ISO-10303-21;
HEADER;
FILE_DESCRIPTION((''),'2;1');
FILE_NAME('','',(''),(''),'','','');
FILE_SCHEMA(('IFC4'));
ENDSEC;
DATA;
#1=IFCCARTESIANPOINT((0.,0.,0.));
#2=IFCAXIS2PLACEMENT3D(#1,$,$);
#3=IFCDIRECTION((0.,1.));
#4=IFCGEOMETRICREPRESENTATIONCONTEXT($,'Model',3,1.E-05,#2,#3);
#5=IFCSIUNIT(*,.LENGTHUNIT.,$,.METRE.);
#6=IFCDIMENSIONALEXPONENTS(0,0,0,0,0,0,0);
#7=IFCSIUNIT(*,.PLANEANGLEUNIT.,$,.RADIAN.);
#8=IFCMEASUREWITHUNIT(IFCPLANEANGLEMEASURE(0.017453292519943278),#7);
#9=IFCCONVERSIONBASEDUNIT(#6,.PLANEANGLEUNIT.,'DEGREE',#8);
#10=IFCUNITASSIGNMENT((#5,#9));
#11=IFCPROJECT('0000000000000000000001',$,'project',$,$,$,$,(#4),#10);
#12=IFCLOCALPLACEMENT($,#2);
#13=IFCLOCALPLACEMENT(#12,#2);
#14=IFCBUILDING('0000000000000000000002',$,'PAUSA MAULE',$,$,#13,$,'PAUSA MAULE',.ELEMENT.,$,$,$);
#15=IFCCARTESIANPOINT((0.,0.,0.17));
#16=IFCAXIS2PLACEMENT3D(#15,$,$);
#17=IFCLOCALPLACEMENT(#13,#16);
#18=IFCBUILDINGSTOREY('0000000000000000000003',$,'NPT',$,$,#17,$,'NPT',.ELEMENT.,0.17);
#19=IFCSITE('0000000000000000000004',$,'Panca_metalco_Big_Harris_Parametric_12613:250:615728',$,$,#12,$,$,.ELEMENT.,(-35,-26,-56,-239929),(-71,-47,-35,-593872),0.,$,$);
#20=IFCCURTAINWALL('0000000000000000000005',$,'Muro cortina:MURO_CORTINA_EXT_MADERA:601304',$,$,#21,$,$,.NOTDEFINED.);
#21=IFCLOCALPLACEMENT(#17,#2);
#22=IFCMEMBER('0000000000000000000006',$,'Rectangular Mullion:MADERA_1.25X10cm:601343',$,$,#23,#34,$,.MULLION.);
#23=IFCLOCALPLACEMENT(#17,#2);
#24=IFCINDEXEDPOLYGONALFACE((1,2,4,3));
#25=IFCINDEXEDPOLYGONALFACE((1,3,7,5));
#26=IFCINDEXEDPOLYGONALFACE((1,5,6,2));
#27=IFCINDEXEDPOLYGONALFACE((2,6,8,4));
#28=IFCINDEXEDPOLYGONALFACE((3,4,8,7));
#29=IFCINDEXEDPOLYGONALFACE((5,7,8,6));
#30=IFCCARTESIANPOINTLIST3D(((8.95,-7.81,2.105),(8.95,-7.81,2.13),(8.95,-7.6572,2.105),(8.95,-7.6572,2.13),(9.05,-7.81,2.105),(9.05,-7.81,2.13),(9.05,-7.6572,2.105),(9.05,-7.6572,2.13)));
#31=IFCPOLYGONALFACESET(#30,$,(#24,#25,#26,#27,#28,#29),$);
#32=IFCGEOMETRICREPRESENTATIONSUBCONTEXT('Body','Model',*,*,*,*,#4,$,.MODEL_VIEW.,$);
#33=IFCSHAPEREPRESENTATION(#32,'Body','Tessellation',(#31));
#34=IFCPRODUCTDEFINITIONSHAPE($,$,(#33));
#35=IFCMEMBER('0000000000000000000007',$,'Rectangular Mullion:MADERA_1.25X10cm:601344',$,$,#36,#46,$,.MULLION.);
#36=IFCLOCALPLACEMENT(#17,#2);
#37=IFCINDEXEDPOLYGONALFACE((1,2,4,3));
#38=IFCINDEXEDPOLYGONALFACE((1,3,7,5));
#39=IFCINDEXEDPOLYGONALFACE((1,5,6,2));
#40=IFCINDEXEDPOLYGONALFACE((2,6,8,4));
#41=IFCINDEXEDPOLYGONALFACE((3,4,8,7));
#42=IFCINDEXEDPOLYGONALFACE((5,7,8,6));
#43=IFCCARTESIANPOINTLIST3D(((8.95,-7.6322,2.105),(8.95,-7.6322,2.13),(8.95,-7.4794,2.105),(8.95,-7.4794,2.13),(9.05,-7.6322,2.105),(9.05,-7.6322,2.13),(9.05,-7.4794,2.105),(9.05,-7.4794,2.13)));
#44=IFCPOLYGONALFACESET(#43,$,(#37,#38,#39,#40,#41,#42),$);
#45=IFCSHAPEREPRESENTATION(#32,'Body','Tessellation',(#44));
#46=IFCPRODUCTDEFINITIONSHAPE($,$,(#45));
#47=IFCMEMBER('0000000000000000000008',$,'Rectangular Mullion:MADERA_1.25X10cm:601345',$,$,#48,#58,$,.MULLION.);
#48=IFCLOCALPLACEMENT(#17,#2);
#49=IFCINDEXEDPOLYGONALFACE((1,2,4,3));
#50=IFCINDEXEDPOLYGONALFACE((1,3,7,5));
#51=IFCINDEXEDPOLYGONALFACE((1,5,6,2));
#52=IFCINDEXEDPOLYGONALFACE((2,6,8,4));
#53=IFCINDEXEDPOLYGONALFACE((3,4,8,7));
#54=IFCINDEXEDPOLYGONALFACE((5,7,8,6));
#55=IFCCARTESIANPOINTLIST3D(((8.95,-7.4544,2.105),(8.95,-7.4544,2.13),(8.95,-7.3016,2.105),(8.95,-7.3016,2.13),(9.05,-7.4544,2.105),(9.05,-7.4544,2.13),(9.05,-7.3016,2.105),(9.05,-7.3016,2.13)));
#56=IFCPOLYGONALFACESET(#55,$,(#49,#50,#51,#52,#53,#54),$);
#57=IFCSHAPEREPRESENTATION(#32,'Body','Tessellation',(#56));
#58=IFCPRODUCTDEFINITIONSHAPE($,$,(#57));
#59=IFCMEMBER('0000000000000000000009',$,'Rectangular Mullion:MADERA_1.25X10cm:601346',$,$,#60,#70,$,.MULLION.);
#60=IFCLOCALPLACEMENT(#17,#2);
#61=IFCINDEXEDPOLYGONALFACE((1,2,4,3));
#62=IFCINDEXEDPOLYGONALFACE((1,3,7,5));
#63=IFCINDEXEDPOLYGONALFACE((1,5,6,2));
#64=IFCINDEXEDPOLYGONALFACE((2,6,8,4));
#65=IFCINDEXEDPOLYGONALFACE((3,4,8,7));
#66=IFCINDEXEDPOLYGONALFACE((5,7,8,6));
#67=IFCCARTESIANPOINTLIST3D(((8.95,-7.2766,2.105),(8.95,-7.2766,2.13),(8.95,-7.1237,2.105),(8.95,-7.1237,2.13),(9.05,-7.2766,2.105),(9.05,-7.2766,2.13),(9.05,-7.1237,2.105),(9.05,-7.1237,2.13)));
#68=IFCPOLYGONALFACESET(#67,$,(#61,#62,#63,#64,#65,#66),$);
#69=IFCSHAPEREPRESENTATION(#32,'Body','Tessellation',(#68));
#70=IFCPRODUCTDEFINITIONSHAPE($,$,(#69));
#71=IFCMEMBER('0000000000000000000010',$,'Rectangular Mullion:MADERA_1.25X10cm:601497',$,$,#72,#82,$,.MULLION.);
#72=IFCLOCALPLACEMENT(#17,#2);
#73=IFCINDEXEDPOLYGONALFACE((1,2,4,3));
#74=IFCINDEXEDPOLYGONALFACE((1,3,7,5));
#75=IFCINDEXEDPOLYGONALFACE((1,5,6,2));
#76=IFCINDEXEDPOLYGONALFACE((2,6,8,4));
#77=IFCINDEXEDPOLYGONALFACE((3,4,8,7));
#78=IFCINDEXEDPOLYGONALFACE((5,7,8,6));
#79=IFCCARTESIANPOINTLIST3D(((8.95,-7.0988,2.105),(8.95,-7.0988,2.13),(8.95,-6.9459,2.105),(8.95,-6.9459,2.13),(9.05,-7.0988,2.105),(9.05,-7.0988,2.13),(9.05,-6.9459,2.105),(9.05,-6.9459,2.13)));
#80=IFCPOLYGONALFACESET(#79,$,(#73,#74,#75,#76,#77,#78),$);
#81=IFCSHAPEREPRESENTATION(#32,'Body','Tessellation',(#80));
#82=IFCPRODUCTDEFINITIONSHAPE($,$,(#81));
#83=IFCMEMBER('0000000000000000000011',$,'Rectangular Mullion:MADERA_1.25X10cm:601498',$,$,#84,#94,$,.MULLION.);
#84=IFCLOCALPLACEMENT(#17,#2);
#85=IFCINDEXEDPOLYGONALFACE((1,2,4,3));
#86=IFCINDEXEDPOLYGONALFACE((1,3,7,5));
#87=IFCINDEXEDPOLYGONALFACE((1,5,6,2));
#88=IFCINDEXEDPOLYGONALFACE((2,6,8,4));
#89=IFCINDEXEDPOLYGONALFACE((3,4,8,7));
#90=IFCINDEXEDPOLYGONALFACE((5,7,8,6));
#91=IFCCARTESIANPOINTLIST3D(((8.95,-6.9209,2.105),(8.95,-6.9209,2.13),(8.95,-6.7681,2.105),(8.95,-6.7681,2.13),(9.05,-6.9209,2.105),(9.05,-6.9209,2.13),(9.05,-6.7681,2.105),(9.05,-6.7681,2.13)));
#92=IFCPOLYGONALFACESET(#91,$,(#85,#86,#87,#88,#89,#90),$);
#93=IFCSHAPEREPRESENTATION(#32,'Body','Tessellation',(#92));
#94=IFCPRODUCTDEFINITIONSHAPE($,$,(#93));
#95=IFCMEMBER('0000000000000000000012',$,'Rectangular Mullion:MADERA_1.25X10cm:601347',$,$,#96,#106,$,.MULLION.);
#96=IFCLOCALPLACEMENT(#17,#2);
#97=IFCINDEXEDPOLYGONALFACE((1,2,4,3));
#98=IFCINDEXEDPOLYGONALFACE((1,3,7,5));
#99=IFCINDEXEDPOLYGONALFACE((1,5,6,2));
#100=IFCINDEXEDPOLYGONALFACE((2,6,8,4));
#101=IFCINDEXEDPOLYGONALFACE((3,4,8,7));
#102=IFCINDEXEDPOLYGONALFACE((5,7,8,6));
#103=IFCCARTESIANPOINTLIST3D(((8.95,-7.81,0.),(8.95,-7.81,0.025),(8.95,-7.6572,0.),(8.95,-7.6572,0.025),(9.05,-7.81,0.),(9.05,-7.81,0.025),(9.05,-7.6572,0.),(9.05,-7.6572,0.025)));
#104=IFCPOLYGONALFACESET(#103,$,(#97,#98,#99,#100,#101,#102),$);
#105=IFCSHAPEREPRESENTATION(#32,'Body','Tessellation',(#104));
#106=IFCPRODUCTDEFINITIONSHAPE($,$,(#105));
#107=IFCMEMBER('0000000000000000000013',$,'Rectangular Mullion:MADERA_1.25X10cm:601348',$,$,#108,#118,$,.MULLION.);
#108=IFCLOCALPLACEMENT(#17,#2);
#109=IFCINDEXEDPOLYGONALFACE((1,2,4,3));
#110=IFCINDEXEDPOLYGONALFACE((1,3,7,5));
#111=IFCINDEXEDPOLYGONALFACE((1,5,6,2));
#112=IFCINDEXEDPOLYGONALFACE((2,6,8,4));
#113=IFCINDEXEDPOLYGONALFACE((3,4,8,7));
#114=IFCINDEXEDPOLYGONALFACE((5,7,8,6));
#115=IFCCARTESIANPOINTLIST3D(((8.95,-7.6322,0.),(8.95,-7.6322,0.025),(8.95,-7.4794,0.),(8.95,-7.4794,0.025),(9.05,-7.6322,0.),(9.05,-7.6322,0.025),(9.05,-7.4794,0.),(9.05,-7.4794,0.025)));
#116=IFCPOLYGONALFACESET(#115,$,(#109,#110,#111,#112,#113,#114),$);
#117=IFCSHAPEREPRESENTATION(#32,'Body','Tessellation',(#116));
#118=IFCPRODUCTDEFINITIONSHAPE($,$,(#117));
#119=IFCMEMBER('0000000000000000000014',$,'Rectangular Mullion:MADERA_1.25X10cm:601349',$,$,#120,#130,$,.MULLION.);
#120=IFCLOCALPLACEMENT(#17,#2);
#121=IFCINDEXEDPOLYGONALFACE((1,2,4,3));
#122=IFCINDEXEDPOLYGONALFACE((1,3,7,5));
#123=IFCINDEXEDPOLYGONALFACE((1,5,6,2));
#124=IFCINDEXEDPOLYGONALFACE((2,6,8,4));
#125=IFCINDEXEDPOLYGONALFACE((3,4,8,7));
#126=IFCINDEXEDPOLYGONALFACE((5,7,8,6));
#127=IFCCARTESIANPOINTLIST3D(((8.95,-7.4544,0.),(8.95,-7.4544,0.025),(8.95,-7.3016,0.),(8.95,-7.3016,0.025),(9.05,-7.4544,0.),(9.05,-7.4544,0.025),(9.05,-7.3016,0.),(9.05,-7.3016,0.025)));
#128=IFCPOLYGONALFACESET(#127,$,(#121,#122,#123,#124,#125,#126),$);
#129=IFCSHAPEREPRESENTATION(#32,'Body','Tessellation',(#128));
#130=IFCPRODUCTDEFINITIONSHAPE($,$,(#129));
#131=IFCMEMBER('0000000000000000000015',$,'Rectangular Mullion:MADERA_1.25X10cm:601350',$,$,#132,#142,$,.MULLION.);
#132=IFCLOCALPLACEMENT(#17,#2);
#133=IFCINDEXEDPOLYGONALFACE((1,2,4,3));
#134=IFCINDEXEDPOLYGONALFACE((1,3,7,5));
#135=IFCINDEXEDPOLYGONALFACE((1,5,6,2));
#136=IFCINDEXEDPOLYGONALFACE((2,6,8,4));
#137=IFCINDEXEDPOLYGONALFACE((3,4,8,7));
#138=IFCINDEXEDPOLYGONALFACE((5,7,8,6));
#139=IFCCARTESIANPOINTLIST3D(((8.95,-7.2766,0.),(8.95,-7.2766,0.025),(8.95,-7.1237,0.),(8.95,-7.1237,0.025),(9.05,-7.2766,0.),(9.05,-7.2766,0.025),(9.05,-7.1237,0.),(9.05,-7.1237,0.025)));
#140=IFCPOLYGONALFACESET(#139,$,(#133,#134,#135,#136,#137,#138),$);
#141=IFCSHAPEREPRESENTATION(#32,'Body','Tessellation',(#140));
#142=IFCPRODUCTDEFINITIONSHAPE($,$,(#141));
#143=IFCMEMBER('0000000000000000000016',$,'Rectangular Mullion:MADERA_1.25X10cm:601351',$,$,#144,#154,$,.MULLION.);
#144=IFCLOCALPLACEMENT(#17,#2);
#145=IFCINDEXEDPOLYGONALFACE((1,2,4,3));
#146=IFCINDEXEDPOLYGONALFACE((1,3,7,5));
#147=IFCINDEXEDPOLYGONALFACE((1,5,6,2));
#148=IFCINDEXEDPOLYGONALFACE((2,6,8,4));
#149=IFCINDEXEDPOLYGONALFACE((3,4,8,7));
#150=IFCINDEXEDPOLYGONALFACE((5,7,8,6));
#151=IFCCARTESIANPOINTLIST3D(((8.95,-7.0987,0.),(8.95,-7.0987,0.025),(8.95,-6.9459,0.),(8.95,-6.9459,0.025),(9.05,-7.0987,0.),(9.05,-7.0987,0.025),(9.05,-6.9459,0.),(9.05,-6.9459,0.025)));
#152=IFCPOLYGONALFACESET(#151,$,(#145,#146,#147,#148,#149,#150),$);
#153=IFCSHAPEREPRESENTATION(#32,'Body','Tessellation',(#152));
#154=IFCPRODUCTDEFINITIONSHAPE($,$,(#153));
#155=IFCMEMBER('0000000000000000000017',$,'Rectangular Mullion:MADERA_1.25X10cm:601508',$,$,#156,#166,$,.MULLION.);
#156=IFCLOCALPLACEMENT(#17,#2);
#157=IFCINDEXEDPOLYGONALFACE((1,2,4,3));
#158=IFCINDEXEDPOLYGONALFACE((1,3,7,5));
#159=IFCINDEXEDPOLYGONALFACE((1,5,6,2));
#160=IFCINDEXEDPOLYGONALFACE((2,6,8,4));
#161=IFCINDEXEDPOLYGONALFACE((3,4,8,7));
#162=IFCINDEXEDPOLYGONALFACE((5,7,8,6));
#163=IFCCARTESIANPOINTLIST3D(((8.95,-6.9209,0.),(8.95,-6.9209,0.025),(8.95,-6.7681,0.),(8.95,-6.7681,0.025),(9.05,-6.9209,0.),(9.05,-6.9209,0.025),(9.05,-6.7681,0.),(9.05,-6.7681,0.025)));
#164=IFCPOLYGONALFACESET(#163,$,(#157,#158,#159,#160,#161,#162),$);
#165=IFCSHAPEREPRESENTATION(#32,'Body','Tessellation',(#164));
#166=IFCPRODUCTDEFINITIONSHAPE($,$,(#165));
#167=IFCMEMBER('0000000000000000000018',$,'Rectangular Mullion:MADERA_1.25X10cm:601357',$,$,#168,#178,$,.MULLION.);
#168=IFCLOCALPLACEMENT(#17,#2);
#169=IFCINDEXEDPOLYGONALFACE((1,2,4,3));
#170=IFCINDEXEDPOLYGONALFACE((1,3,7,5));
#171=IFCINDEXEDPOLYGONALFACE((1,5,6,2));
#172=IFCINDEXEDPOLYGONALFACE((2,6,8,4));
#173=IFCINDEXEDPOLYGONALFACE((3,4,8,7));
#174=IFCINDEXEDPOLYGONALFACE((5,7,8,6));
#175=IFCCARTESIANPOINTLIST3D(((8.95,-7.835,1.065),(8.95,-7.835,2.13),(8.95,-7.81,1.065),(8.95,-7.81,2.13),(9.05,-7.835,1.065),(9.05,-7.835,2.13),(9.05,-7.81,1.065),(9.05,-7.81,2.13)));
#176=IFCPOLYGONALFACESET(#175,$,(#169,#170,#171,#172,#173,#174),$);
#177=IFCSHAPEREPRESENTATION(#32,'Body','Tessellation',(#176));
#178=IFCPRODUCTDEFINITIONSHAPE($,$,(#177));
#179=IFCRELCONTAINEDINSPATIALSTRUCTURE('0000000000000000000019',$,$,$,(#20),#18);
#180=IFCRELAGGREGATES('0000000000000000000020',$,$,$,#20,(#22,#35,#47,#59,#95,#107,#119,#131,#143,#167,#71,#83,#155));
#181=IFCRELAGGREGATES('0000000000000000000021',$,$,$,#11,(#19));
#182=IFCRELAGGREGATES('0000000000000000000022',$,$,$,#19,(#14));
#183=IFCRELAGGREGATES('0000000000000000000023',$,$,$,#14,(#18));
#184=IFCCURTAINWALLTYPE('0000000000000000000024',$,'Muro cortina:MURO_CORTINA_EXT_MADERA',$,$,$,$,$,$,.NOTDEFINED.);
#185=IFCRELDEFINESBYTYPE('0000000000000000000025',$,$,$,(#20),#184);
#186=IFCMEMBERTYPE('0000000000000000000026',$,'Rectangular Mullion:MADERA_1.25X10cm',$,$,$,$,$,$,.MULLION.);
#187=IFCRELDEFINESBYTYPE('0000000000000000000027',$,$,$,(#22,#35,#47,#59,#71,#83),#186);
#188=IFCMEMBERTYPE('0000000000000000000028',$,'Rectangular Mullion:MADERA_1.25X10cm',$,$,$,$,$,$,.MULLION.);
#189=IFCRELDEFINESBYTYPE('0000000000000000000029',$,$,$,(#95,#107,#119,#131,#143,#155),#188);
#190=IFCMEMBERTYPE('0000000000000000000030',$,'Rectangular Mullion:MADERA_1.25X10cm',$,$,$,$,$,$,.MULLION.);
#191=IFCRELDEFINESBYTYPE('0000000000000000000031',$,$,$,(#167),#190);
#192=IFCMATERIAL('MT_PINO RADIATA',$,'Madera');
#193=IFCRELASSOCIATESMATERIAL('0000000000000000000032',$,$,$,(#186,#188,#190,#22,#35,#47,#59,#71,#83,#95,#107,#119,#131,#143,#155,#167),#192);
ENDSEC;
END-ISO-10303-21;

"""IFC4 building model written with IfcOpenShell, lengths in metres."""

from ifc_helpers import new_model, entity, si_unit, converted_unit, direction, frame, frame_2d, origin, place, context, subcontext, project, spatial, rectangle, extrude, source, transform, mapped, material, material_profile, profile_set, profile_usage, type_object, type_shapes, element, aggregate, save


model = new_model("IFC4")

# Units and contexts
model_context = context("Model", 3, precision=1e-05, world=origin(), true_north=direction((0.0, 1.0)))
body_context = subcontext(model_context, "Body", "Model", "MODEL_VIEW")
ifc_project = project(units=[si_unit("LENGTHUNIT", "METRE"), converted_unit("PLANEANGLEUNIT", "DEGREE", entity("IfcPlaneAngleMeasure", 0.017453292519943278), si_unit("PLANEANGLEUNIT", "RADIAN"), dimensions=[0, 0, 0, 0, 0, 0, 0])], contexts=[model_context])

# Site, building, storey
site_placement = place(None, origin())
site = spatial("IfcSite", under=ifc_project, at=site_placement, Name="Panca_metalco_Big_Harris_Parametric_12613:250:615728", CompositionType="ELEMENT", RefLatitude=(-35, -26, -56, -239929), RefLongitude=(-71, -47, -35, -593872), RefElevation=0.0)
building_placement = place(site_placement, origin())
building = spatial("IfcBuilding", under=site, at=building_placement, Name="PAUSA MAULE", LongName="PAUSA MAULE", CompositionType="ELEMENT")
storey_placement = place(building_placement, frame((0.0, 0.0, 0.17)))
storey = spatial("IfcBuildingStorey", under=building, at=storey_placement, Name="NPT", LongName="NPT", CompositionType="ELEMENT", Elevation=0.17)

# Curtain wall, members
curtain_wall_type = type_object("IfcCurtainWallType", Name="Muro cortina:MURO_CORTINA_EXT_MADERA", PredefinedType="NOTDEFINED")
curtain_wall_placement = place(storey_placement, frame((0.0, 0.0, -0.17)))
curtain_wall = element("IfcCurtainWall", 1, at=curtain_wall_placement, inside=storey, type_object=curtain_wall_type, Name="Muro cortina:MURO_CORTINA_EXT_MADERA:601304", PredefinedType="NOTDEFINED")
ifc_material = material(Name="MT_PINO RADIATA", Category="Madera")
ifc_material_profile = material_profile(ifc_material, rectangle(XDim=0.025, YDim=0.1, at=frame_2d((0.0, 0.0), x_axis=(1.0, 0.0))), Name="MADERA_1.25X10cm")
ifc_profile_set = profile_set([ifc_material_profile], Name="MADERA_1.25X10cm")
ifc_profile_usage = profile_usage(ifc_profile_set)
member_type_1 = type_object("IfcMemberType", Name="Rectangular Mullion:MADERA_1.25X10cm", PredefinedType="MULLION", material=ifc_profile_set)
shared_shape_1 = source(origin(), body_context, "Body", "SweptSolid", [
    extrude(rectangle(XDim=0.025, YDim=0.1, at=frame_2d((0.0, 0.0), x_axis=(1.0, 0.0))), frame((-0.0125, 0.0, -0.1528), z_axis=(0.0, 0.0, 1.0), x_axis=(-1.0, 0.0, 0.0)), (0.0, 0.0, 1.0), 0.1528),
])
type_shapes(member_type_1, [shared_shape_1])
member_1_placement = place(curtain_wall_placement, frame((9.0, -7.6572, 2.3), z_axis=(0.0, 1.0, 0.0), x_axis=(0.0, 0.0, 1.0)))
member_1 = element("IfcMember", 2, at=member_1_placement, type_object=member_type_1, material=ifc_profile_usage, Name="Rectangular Mullion:MADERA_1.25X10cm:601343", PredefinedType="MULLION", context=body_context, shape_type="MappedRepresentation", body=[
    mapped(shared_shape_1, transform((0.0, 0.0, 0.0), scale=1.0)),
])
member_2_placement = place(curtain_wall_placement, frame((9.0, -7.4794, 2.3), z_axis=(0.0, 1.0, 0.0), x_axis=(0.0, 0.0, 1.0)))
member_2 = element("IfcMember", 3, at=member_2_placement, type_object=member_type_1, material=ifc_profile_usage, Name="Rectangular Mullion:MADERA_1.25X10cm:601344", PredefinedType="MULLION", context=body_context, shape_type="MappedRepresentation", body=[
    mapped(shared_shape_1, transform((0.0, 0.0, 0.0), scale=1.0)),
])
member_3_placement = place(curtain_wall_placement, frame((9.0, -7.3016, 2.3), z_axis=(0.0, 1.0, 0.0), x_axis=(0.0, 0.0, 1.0)))
member_3 = element("IfcMember", 4, at=member_3_placement, type_object=member_type_1, material=ifc_profile_usage, Name="Rectangular Mullion:MADERA_1.25X10cm:601345", PredefinedType="MULLION", context=body_context, shape_type="MappedRepresentation", body=[
    mapped(shared_shape_1, transform((0.0, 0.0, 0.0), scale=1.0)),
])
member_4_placement = place(curtain_wall_placement, frame((9.0, -7.1237, 2.3), z_axis=(0.0, 1.0, 0.0), x_axis=(0.0, 0.0, 1.0)))
member_4 = element("IfcMember", 5, at=member_4_placement, type_object=member_type_1, material=ifc_profile_usage, Name="Rectangular Mullion:MADERA_1.25X10cm:601346", PredefinedType="MULLION", context=body_context, shape_type="MappedRepresentation", body=[
    mapped(shared_shape_1, transform((0.0, 0.0, 0.0), scale=1.0)),
])
member_5_placement = place(curtain_wall_placement, frame((9.0, -6.9459, 2.3), z_axis=(0.0, 1.0, 0.0), x_axis=(0.0, 0.0, 1.0)))
member_5 = element("IfcMember", 6, at=member_5_placement, type_object=member_type_1, material=ifc_profile_usage, Name="Rectangular Mullion:MADERA_1.25X10cm:601497", PredefinedType="MULLION", context=body_context, shape_type="MappedRepresentation", body=[
    mapped(shared_shape_1, transform((0.0, 0.0, 0.0), scale=1.0)),
])
member_6_placement = place(curtain_wall_placement, frame((9.0, -6.7681, 2.3), z_axis=(0.0, 1.0, 0.0), x_axis=(0.0, 0.0, 1.0)))
member_6 = element("IfcMember", 7, at=member_6_placement, type_object=member_type_1, material=ifc_profile_usage, Name="Rectangular Mullion:MADERA_1.25X10cm:601498", PredefinedType="MULLION", context=body_context, shape_type="MappedRepresentation", body=[
    mapped(shared_shape_1, transform((0.0, 0.0, 0.0), scale=1.0)),
])
member_type_2 = type_object("IfcMemberType", Name="Rectangular Mullion:MADERA_1.25X10cm", PredefinedType="MULLION", material=ifc_profile_set)
shared_shape_2 = source(origin(), body_context, "Body", "SweptSolid", [
    extrude(rectangle(XDim=0.025, YDim=0.1, at=frame_2d((0.0, 0.0), x_axis=(1.0, 0.0))), frame((-0.0125, 0.0, -0.1528), z_axis=(0.0, 0.0, 1.0), x_axis=(-1.0, 0.0, 0.0)), (0.0, 0.0, 1.0), 0.1528),
])
type_shapes(member_type_2, [shared_shape_2])
member_7_placement = place(curtain_wall_placement, frame((9.0, -7.81, 0.17), z_axis=(0.0, -1.0, 0.0), x_axis=(0.0, 0.0, -1.0)))
member_7 = element("IfcMember", 8, at=member_7_placement, type_object=member_type_2, material=ifc_profile_usage, Name="Rectangular Mullion:MADERA_1.25X10cm:601347", PredefinedType="MULLION", context=body_context, shape_type="MappedRepresentation", body=[
    mapped(shared_shape_2, transform((0.0, 0.0, 0.0), scale=1.0)),
])
member_8_placement = place(curtain_wall_placement, frame((9.0, -7.6322, 0.17), z_axis=(0.0, -1.0, 0.0), x_axis=(0.0, 0.0, -1.0)))
member_8 = element("IfcMember", 9, at=member_8_placement, type_object=member_type_2, material=ifc_profile_usage, Name="Rectangular Mullion:MADERA_1.25X10cm:601348", PredefinedType="MULLION", context=body_context, shape_type="MappedRepresentation", body=[
    mapped(shared_shape_2, transform((0.0, 0.0, 0.0), scale=1.0)),
])
member_9_placement = place(curtain_wall_placement, frame((9.0, -7.4544, 0.17), z_axis=(0.0, -1.0, 0.0), x_axis=(0.0, 0.0, -1.0)))
member_9 = element("IfcMember", 10, at=member_9_placement, type_object=member_type_2, material=ifc_profile_usage, Name="Rectangular Mullion:MADERA_1.25X10cm:601349", PredefinedType="MULLION", context=body_context, shape_type="MappedRepresentation", body=[
    mapped(shared_shape_2, transform((0.0, 0.0, 0.0), scale=1.0)),
])
member_10_placement = place(curtain_wall_placement, frame((9.0, -7.2766, 0.17), z_axis=(0.0, -1.0, 0.0), x_axis=(0.0, 0.0, -1.0)))
member_10 = element("IfcMember", 11, at=member_10_placement, type_object=member_type_2, material=ifc_profile_usage, Name="Rectangular Mullion:MADERA_1.25X10cm:601350", PredefinedType="MULLION", context=body_context, shape_type="MappedRepresentation", body=[
    mapped(shared_shape_2, transform((0.0, 0.0, 0.0), scale=1.0)),
])
member_11_placement = place(curtain_wall_placement, frame((9.0, -7.0987, 0.17), z_axis=(0.0, -1.0, 0.0), x_axis=(0.0, 0.0, -1.0)))
member_11 = element("IfcMember", 12, at=member_11_placement, type_object=member_type_2, material=ifc_profile_usage, Name="Rectangular Mullion:MADERA_1.25X10cm:601351", PredefinedType="MULLION", context=body_context, shape_type="MappedRepresentation", body=[
    mapped(shared_shape_2, transform((0.0, 0.0, 0.0), scale=1.0)),
])
member_12_placement = place(curtain_wall_placement, frame((9.0, -6.9209, 0.17), z_axis=(0.0, -1.0, 0.0), x_axis=(0.0, 0.0, -1.0)))
member_12 = element("IfcMember", 13, at=member_12_placement, type_object=member_type_2, material=ifc_profile_usage, Name="Rectangular Mullion:MADERA_1.25X10cm:601508", PredefinedType="MULLION", context=body_context, shape_type="MappedRepresentation", body=[
    mapped(shared_shape_2, transform((0.0, 0.0, 0.0), scale=1.0)),
])
member_type_3 = type_object("IfcMemberType", Name="Rectangular Mullion:MADERA_1.25X10cm", PredefinedType="MULLION", material=ifc_profile_set)
shared_shape_3 = source(origin(), body_context, "Body", "SweptSolid", [
    extrude(rectangle(XDim=0.025, YDim=0.1, at=frame_2d((0.0, 0.0), x_axis=(1.0, 0.0))), frame((-0.0125, 0.0, -1.065), z_axis=(0.0, 0.0, 1.0), x_axis=(-1.0, 0.0, 0.0)), (0.0, 0.0, 1.0), 1.065),
])
type_shapes(member_type_3, [shared_shape_3])
member_13_placement = place(curtain_wall_placement, frame((9.0, -7.835, 2.3), z_axis=(0.0, 0.0, 1.0), x_axis=(0.0, -1.0, 0.0)))
member_13 = element("IfcMember", 14, at=member_13_placement, type_object=member_type_3, material=ifc_profile_usage, Name="Rectangular Mullion:MADERA_1.25X10cm:601357", PredefinedType="MULLION", context=body_context, shape_type="MappedRepresentation", body=[
    mapped(shared_shape_3, transform((0.0, 0.0, 0.0), scale=1.0)),
])
aggregate(curtain_wall, [member_1, member_2, member_3, member_4, member_7, member_8, member_9, member_10, member_11, member_13, member_5, member_6, member_12])

save(model, "model.ifc")
